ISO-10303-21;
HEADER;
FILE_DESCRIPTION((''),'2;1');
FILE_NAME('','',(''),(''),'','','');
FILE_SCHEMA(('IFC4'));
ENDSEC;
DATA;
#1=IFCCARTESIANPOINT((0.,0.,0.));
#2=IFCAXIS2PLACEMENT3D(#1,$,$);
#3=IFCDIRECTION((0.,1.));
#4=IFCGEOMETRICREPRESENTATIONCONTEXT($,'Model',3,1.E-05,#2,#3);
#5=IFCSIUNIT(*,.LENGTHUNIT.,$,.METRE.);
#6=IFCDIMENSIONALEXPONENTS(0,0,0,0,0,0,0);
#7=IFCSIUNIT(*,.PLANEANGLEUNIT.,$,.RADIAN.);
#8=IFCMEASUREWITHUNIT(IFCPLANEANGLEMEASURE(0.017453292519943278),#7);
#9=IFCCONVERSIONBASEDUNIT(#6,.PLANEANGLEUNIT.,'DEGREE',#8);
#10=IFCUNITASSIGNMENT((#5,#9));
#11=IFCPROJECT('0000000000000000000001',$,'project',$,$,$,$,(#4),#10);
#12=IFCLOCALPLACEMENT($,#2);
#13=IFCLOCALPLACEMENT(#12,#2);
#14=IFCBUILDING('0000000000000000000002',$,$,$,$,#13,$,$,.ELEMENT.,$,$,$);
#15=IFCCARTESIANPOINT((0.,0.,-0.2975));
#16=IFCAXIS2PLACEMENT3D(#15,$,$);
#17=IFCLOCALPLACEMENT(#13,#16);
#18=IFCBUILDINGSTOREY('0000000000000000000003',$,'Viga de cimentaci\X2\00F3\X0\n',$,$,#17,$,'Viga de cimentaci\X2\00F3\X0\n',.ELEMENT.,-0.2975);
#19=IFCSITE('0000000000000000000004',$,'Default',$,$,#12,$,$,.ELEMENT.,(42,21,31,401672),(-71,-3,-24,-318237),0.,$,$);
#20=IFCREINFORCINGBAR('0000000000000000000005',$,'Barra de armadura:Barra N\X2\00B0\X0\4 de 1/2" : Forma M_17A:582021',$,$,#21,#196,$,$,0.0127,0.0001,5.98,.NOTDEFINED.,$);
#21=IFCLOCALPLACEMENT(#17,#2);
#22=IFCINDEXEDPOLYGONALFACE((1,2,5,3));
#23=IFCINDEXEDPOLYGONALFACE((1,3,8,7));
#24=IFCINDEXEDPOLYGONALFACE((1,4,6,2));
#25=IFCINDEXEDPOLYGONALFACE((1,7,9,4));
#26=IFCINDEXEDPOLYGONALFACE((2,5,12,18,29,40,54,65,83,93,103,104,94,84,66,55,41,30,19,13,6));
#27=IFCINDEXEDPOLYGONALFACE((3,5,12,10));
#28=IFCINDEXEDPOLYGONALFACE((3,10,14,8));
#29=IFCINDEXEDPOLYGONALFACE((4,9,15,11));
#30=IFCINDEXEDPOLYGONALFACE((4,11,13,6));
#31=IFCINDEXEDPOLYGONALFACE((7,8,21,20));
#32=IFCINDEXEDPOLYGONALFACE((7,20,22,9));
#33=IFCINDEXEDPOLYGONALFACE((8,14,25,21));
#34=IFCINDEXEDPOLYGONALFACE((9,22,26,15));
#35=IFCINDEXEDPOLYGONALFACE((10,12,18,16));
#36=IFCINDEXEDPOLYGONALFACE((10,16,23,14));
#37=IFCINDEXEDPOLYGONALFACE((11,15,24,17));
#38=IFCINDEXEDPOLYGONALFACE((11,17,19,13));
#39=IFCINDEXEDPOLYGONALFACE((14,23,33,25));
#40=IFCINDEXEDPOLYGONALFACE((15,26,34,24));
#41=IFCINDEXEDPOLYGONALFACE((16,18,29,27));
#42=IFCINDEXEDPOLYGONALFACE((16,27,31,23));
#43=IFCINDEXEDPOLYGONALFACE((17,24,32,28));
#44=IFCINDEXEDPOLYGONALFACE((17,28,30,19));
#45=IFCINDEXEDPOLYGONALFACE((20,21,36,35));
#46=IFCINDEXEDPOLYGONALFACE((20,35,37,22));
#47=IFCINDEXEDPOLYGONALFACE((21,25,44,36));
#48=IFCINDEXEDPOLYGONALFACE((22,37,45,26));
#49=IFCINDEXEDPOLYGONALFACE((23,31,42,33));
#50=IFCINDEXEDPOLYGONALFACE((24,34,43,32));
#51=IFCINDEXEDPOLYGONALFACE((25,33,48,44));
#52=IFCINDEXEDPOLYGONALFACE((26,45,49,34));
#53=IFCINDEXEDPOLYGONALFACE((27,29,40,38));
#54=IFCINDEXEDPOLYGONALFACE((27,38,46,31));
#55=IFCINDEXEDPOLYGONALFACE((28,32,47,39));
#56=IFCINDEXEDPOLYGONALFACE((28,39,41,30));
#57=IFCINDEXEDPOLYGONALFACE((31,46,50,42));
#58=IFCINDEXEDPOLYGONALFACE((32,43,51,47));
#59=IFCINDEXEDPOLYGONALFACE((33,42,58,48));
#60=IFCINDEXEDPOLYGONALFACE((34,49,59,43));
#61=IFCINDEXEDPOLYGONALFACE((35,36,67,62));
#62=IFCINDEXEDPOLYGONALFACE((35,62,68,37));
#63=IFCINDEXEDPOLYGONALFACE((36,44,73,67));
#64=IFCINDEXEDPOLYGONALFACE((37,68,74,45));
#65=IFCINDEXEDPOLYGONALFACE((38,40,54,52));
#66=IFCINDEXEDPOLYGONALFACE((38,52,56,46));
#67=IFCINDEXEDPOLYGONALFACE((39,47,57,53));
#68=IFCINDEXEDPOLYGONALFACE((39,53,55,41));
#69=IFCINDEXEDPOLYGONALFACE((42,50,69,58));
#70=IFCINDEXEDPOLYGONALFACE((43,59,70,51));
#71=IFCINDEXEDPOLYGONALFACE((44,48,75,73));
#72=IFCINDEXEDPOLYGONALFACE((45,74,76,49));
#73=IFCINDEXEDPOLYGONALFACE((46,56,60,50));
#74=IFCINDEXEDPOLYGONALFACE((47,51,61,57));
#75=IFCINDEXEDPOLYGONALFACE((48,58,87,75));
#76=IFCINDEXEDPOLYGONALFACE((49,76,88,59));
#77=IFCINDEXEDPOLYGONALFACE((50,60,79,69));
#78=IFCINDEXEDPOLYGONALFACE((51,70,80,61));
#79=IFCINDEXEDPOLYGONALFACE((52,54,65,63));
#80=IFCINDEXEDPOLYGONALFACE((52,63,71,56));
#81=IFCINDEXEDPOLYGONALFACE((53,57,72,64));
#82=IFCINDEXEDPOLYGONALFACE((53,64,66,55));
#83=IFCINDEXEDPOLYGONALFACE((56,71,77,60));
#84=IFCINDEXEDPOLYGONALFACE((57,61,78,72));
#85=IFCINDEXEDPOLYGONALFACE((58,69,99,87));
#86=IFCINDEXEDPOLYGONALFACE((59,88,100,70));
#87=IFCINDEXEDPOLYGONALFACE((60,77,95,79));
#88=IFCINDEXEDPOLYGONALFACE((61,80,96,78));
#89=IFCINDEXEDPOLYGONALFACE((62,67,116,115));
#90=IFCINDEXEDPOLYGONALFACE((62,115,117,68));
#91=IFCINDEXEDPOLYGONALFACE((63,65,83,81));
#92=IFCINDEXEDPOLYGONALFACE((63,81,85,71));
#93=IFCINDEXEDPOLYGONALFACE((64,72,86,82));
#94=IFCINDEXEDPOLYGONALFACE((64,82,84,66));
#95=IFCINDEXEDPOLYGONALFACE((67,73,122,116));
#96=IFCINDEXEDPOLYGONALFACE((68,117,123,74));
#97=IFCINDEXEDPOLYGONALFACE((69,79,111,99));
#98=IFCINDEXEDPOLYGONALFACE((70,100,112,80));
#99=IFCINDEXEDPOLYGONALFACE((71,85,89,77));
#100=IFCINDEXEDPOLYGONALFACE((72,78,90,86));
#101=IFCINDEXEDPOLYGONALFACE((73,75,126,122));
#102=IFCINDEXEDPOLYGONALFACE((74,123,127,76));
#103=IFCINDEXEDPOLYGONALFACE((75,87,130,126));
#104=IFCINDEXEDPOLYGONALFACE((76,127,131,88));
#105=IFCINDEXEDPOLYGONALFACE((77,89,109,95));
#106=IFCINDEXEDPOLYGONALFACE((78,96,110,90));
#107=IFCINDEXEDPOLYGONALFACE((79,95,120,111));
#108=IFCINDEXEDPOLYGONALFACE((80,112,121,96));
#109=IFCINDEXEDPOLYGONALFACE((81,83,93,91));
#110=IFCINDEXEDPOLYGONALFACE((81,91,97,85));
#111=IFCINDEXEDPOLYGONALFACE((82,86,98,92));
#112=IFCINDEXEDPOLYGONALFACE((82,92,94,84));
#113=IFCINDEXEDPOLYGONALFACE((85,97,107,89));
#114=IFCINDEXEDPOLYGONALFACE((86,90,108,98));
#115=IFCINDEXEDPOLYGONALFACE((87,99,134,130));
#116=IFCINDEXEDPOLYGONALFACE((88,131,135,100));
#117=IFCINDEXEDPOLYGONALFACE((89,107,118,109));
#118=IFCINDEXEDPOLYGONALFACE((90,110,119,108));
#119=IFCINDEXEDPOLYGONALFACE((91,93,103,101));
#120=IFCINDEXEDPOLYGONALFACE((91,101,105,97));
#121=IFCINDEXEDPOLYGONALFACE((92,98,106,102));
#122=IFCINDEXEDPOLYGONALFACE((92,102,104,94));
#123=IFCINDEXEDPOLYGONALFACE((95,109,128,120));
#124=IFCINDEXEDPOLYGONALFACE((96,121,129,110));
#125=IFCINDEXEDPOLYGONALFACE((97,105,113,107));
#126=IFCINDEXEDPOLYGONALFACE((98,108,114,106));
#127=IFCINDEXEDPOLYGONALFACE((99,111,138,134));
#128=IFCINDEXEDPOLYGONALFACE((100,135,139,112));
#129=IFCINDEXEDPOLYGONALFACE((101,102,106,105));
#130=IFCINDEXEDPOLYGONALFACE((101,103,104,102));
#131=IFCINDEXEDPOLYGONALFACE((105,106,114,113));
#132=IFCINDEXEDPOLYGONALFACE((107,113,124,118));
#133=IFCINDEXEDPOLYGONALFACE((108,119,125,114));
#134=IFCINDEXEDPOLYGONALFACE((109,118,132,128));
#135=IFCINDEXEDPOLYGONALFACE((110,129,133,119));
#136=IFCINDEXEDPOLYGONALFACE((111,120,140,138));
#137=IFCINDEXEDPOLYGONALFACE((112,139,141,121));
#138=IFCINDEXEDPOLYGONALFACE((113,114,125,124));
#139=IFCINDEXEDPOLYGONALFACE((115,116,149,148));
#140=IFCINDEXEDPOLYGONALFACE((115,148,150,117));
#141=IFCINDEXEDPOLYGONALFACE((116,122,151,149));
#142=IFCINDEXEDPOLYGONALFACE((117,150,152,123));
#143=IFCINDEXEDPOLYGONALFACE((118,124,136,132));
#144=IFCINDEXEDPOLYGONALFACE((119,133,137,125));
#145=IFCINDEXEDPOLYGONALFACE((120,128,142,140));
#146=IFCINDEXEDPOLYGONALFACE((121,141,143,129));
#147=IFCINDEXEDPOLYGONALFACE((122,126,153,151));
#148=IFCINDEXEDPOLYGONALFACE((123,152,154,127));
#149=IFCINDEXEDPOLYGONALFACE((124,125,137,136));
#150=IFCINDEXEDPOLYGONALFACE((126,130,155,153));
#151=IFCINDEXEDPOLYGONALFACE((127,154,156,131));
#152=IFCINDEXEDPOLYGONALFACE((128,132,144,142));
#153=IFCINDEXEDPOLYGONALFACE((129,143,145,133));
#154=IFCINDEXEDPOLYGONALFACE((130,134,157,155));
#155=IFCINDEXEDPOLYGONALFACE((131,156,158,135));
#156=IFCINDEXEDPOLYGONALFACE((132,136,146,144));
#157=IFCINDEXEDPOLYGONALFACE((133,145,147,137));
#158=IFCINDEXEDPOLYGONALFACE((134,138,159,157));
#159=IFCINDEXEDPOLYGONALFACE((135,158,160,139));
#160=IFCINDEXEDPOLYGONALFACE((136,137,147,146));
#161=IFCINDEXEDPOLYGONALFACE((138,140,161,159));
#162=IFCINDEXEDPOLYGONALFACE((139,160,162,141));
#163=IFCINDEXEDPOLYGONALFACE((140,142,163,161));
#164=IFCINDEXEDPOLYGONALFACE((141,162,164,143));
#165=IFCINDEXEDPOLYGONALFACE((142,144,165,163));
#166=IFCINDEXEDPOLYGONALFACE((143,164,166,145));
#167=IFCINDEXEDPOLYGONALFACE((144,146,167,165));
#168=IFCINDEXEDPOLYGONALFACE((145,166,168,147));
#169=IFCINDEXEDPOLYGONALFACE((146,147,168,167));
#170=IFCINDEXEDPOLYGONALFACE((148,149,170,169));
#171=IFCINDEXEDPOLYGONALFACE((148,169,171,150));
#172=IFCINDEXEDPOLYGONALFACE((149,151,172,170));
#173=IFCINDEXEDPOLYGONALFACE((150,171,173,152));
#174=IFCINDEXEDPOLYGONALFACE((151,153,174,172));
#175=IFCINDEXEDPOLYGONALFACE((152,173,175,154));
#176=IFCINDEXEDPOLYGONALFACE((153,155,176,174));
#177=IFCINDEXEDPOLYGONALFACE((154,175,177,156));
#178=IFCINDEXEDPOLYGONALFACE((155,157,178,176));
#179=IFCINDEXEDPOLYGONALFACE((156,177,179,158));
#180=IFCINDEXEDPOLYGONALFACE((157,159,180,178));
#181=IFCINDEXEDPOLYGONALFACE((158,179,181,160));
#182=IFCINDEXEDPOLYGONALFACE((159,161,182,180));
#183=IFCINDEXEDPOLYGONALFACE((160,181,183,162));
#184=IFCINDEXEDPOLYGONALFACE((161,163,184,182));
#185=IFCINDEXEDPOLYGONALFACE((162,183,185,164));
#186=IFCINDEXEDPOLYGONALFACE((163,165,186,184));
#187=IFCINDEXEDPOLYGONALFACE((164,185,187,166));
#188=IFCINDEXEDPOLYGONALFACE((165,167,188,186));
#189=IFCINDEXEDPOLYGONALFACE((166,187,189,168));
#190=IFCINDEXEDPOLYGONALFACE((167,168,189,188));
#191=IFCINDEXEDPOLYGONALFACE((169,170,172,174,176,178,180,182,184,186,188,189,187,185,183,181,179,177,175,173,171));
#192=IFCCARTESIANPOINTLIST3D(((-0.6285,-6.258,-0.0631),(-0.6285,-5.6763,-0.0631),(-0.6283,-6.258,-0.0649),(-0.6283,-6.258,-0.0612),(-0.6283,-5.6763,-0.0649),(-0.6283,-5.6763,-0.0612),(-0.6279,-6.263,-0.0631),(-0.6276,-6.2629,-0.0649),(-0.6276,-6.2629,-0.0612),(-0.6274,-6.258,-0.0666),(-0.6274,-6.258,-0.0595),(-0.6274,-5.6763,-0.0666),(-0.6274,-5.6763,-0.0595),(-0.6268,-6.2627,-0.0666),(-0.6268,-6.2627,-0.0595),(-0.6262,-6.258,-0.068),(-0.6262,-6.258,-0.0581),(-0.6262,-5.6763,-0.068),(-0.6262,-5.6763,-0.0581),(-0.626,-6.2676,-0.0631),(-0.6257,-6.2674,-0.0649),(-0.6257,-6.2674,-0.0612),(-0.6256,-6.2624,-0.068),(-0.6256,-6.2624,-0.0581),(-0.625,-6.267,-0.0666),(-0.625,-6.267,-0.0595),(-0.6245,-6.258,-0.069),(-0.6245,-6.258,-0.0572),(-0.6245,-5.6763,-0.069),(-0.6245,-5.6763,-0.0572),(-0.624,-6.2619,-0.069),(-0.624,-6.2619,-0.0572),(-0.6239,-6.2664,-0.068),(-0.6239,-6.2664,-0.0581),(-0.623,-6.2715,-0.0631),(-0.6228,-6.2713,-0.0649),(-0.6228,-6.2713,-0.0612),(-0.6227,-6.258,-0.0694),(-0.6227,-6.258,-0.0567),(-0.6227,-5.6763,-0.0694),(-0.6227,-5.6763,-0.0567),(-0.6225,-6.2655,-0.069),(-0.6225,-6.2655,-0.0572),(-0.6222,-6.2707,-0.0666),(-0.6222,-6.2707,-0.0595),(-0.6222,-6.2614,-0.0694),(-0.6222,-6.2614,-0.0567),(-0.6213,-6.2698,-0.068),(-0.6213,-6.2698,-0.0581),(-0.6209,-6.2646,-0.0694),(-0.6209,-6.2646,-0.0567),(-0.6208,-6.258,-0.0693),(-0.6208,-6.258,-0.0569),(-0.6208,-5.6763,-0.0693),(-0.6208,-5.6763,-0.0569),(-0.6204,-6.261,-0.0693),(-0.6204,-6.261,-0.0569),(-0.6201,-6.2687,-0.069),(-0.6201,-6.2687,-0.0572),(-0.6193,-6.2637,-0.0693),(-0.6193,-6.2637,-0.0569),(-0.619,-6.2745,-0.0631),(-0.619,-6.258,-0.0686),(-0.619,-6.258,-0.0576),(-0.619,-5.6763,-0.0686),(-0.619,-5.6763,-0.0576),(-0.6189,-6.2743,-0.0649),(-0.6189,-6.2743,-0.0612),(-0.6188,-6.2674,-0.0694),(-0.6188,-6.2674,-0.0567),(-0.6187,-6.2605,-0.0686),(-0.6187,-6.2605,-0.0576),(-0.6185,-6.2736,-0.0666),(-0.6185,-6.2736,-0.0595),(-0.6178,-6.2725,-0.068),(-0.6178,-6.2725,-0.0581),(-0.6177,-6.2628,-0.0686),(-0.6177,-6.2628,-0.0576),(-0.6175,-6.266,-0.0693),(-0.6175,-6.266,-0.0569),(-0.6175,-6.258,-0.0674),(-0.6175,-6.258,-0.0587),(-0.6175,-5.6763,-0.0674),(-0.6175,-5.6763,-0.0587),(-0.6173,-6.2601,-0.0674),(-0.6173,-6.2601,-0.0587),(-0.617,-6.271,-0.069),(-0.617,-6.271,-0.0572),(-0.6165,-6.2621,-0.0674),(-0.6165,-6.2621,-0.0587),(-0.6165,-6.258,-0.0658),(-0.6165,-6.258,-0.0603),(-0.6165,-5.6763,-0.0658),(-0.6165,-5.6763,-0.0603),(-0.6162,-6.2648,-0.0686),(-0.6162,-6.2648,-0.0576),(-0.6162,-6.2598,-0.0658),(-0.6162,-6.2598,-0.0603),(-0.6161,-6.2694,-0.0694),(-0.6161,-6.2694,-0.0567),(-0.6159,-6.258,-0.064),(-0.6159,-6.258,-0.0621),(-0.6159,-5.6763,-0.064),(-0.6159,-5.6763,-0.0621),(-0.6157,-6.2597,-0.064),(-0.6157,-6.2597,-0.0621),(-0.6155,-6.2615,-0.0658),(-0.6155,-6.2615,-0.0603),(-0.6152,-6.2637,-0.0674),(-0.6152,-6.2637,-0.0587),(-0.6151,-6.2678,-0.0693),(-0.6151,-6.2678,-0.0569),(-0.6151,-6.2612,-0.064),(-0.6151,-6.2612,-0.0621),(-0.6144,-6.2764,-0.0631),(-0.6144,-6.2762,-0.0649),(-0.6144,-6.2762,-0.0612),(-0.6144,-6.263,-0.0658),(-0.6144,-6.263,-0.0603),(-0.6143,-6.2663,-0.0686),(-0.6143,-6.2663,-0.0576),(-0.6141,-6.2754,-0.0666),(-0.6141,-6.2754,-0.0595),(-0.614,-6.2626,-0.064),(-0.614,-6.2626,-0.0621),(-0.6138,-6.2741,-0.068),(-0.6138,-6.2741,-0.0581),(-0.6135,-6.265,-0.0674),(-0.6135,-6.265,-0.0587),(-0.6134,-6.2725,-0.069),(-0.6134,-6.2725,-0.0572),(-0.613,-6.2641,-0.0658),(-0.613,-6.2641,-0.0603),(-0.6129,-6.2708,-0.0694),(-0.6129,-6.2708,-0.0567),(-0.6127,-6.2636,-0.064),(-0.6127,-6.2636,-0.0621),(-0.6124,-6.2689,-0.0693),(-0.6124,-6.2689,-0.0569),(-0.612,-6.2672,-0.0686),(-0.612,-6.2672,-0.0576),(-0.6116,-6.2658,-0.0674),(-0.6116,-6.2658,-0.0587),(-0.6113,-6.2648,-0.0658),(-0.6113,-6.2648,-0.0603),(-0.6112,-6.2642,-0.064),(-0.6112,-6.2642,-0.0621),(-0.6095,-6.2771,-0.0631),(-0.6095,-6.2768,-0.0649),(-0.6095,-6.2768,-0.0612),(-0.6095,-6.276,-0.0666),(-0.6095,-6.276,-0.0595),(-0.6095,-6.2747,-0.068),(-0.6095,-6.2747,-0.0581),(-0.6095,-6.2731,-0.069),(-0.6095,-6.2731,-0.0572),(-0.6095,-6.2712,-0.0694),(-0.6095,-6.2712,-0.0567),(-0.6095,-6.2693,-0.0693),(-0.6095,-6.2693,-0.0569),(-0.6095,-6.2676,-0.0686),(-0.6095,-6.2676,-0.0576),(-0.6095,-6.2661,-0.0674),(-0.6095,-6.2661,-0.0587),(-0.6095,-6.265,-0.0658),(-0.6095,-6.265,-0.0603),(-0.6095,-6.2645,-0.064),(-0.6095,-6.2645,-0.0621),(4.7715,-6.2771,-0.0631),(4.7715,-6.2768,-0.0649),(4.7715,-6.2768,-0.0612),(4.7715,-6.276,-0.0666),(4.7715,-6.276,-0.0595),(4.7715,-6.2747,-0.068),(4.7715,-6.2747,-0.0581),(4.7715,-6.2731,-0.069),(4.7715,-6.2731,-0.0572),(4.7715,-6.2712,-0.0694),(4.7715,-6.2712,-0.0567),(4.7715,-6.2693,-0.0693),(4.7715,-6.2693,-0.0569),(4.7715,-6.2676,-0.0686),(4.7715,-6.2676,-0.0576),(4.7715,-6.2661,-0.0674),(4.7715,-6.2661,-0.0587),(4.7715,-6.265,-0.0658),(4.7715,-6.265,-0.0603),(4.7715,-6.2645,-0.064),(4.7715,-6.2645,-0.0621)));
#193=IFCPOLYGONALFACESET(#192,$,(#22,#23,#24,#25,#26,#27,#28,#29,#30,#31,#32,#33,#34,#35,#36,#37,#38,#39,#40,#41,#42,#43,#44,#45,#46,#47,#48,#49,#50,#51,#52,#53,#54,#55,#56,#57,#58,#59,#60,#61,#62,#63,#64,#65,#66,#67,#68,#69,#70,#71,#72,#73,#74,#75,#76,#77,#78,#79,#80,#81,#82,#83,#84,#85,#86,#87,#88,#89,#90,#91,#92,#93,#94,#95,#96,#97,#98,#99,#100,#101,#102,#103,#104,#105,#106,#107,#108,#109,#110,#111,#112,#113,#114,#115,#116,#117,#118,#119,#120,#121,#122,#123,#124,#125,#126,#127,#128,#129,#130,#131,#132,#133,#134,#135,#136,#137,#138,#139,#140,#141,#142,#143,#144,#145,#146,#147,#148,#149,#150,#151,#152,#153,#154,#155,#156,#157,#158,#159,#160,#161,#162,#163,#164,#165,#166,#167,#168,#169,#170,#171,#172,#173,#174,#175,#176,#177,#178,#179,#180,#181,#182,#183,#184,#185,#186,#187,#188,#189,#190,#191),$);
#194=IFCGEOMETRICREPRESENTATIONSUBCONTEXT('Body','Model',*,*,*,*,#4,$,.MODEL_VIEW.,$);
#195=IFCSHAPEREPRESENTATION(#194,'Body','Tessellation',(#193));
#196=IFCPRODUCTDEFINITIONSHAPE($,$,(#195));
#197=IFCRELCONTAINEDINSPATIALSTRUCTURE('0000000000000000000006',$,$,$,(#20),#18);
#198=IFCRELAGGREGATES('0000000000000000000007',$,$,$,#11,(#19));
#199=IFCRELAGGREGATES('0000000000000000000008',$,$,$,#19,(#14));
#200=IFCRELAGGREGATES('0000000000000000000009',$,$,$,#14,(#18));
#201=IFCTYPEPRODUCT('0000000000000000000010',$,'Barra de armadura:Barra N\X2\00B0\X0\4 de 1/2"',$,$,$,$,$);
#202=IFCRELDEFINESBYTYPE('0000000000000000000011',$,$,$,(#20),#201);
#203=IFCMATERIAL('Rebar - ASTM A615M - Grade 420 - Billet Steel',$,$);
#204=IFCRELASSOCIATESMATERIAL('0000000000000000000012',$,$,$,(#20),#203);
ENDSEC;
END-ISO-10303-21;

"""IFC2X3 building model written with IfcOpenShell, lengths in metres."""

from ifc_helpers import new_model, entity, si_unit, converted_unit, direction, frame, origin, place, context, subcontext, project, spatial, material, type_object, element, save


model = new_model("IFC2X3")

# Units and contexts
model_context = context("Model", 3, precision=1e-05, world=origin(), true_north=direction((0.0, 1.0)))
body_context = subcontext(model_context, "Body", "Model", "MODEL_VIEW")
ifc_project = project(units=[si_unit("LENGTHUNIT", "METRE"), converted_unit("PLANEANGLEUNIT", "DEGREE", entity("IfcPlaneAngleMeasure", 0.017453292519943278), si_unit("PLANEANGLEUNIT", "RADIAN"), dimensions=[0, 0, 0, 0, 0, 0, 0])], contexts=[model_context])

# Site, building, storey
site_placement = place(None, origin())
site = spatial("IfcSite", under=ifc_project, at=site_placement, Name="Default", CompositionType="ELEMENT", RefLatitude=(42, 21, 31, 401672), RefLongitude=(-71, -3, -24, -318237), RefElevation=0.0)
building_placement = place(site_placement, origin())
building = spatial("IfcBuilding", under=site, at=building_placement, CompositionType="ELEMENT")
storey_placement = place(building_placement, frame((0.0, 0.0, -0.2975)))
storey = spatial("IfcBuildingStorey", under=building, at=storey_placement, Name="Viga de cimentación", LongName="Viga de cimentación", CompositionType="ELEMENT", Elevation=-0.2975)

# Reinforcing bar
ifc_material = material(Name="Rebar - ASTM A615M - Grade 420 - Billet Steel")
type_product_1 = type_object("IfcTypeProduct", Name="Barra de armadura:Barra N°4 de 1/2\"")
reinforcing_bar_1_placement = place(storey_placement, origin())
element("IfcReinforcingBar", 1, at=reinforcing_bar_1_placement, inside=storey, type_object=type_product_1, material=ifc_material, Name="Barra de armadura:Barra N°4 de 1/2\" : Forma M_17A:582021", BarLength=5.98, BarRole="NOTDEFINED", CrossSectionArea=0.0001, NominalDiameter=0.0127, context=body_context, shape_type="AdvancedSweptSolid", body=[
    entity("IfcSweptDiskSolid", entity("IfcCompositeCurve", [entity("IfcCompositeCurveSegment", "CONTINUOUS", True, entity("IfcPolyline", [entity("IfcCartesianPoint", [-0.6222, -5.6763, -0.0631]), entity("IfcCartesianPoint", [-0.6222, -6.258, -0.0631])])), entity("IfcCompositeCurveSegment", "CONTINUOUS", True, entity("IfcTrimmedCurve", entity("IfcCircle", entity("IfcAxis2Placement3D", entity("IfcCartesianPoint", [-0.6095, -6.258, -0.0631]), entity("IfcDirection", [0.0, 0.0, 1.0]), entity("IfcDirection", [0.0, -1.0, 0.0])), 0.0127), [entity("IfcParameterValue", 270.0)], [entity("IfcParameterValue", 360.0)], True, "PARAMETER")), entity("IfcCompositeCurveSegment", "CONTINUOUS", True, entity("IfcPolyline", [entity("IfcCartesianPoint", [-0.6095, -6.2707, -0.0631]), entity("IfcCartesianPoint", [4.7715, -6.2707, -0.0631])]))], False), 0.0063, None, 0.0, 92.0),
])

save(model, "model.ifc")
